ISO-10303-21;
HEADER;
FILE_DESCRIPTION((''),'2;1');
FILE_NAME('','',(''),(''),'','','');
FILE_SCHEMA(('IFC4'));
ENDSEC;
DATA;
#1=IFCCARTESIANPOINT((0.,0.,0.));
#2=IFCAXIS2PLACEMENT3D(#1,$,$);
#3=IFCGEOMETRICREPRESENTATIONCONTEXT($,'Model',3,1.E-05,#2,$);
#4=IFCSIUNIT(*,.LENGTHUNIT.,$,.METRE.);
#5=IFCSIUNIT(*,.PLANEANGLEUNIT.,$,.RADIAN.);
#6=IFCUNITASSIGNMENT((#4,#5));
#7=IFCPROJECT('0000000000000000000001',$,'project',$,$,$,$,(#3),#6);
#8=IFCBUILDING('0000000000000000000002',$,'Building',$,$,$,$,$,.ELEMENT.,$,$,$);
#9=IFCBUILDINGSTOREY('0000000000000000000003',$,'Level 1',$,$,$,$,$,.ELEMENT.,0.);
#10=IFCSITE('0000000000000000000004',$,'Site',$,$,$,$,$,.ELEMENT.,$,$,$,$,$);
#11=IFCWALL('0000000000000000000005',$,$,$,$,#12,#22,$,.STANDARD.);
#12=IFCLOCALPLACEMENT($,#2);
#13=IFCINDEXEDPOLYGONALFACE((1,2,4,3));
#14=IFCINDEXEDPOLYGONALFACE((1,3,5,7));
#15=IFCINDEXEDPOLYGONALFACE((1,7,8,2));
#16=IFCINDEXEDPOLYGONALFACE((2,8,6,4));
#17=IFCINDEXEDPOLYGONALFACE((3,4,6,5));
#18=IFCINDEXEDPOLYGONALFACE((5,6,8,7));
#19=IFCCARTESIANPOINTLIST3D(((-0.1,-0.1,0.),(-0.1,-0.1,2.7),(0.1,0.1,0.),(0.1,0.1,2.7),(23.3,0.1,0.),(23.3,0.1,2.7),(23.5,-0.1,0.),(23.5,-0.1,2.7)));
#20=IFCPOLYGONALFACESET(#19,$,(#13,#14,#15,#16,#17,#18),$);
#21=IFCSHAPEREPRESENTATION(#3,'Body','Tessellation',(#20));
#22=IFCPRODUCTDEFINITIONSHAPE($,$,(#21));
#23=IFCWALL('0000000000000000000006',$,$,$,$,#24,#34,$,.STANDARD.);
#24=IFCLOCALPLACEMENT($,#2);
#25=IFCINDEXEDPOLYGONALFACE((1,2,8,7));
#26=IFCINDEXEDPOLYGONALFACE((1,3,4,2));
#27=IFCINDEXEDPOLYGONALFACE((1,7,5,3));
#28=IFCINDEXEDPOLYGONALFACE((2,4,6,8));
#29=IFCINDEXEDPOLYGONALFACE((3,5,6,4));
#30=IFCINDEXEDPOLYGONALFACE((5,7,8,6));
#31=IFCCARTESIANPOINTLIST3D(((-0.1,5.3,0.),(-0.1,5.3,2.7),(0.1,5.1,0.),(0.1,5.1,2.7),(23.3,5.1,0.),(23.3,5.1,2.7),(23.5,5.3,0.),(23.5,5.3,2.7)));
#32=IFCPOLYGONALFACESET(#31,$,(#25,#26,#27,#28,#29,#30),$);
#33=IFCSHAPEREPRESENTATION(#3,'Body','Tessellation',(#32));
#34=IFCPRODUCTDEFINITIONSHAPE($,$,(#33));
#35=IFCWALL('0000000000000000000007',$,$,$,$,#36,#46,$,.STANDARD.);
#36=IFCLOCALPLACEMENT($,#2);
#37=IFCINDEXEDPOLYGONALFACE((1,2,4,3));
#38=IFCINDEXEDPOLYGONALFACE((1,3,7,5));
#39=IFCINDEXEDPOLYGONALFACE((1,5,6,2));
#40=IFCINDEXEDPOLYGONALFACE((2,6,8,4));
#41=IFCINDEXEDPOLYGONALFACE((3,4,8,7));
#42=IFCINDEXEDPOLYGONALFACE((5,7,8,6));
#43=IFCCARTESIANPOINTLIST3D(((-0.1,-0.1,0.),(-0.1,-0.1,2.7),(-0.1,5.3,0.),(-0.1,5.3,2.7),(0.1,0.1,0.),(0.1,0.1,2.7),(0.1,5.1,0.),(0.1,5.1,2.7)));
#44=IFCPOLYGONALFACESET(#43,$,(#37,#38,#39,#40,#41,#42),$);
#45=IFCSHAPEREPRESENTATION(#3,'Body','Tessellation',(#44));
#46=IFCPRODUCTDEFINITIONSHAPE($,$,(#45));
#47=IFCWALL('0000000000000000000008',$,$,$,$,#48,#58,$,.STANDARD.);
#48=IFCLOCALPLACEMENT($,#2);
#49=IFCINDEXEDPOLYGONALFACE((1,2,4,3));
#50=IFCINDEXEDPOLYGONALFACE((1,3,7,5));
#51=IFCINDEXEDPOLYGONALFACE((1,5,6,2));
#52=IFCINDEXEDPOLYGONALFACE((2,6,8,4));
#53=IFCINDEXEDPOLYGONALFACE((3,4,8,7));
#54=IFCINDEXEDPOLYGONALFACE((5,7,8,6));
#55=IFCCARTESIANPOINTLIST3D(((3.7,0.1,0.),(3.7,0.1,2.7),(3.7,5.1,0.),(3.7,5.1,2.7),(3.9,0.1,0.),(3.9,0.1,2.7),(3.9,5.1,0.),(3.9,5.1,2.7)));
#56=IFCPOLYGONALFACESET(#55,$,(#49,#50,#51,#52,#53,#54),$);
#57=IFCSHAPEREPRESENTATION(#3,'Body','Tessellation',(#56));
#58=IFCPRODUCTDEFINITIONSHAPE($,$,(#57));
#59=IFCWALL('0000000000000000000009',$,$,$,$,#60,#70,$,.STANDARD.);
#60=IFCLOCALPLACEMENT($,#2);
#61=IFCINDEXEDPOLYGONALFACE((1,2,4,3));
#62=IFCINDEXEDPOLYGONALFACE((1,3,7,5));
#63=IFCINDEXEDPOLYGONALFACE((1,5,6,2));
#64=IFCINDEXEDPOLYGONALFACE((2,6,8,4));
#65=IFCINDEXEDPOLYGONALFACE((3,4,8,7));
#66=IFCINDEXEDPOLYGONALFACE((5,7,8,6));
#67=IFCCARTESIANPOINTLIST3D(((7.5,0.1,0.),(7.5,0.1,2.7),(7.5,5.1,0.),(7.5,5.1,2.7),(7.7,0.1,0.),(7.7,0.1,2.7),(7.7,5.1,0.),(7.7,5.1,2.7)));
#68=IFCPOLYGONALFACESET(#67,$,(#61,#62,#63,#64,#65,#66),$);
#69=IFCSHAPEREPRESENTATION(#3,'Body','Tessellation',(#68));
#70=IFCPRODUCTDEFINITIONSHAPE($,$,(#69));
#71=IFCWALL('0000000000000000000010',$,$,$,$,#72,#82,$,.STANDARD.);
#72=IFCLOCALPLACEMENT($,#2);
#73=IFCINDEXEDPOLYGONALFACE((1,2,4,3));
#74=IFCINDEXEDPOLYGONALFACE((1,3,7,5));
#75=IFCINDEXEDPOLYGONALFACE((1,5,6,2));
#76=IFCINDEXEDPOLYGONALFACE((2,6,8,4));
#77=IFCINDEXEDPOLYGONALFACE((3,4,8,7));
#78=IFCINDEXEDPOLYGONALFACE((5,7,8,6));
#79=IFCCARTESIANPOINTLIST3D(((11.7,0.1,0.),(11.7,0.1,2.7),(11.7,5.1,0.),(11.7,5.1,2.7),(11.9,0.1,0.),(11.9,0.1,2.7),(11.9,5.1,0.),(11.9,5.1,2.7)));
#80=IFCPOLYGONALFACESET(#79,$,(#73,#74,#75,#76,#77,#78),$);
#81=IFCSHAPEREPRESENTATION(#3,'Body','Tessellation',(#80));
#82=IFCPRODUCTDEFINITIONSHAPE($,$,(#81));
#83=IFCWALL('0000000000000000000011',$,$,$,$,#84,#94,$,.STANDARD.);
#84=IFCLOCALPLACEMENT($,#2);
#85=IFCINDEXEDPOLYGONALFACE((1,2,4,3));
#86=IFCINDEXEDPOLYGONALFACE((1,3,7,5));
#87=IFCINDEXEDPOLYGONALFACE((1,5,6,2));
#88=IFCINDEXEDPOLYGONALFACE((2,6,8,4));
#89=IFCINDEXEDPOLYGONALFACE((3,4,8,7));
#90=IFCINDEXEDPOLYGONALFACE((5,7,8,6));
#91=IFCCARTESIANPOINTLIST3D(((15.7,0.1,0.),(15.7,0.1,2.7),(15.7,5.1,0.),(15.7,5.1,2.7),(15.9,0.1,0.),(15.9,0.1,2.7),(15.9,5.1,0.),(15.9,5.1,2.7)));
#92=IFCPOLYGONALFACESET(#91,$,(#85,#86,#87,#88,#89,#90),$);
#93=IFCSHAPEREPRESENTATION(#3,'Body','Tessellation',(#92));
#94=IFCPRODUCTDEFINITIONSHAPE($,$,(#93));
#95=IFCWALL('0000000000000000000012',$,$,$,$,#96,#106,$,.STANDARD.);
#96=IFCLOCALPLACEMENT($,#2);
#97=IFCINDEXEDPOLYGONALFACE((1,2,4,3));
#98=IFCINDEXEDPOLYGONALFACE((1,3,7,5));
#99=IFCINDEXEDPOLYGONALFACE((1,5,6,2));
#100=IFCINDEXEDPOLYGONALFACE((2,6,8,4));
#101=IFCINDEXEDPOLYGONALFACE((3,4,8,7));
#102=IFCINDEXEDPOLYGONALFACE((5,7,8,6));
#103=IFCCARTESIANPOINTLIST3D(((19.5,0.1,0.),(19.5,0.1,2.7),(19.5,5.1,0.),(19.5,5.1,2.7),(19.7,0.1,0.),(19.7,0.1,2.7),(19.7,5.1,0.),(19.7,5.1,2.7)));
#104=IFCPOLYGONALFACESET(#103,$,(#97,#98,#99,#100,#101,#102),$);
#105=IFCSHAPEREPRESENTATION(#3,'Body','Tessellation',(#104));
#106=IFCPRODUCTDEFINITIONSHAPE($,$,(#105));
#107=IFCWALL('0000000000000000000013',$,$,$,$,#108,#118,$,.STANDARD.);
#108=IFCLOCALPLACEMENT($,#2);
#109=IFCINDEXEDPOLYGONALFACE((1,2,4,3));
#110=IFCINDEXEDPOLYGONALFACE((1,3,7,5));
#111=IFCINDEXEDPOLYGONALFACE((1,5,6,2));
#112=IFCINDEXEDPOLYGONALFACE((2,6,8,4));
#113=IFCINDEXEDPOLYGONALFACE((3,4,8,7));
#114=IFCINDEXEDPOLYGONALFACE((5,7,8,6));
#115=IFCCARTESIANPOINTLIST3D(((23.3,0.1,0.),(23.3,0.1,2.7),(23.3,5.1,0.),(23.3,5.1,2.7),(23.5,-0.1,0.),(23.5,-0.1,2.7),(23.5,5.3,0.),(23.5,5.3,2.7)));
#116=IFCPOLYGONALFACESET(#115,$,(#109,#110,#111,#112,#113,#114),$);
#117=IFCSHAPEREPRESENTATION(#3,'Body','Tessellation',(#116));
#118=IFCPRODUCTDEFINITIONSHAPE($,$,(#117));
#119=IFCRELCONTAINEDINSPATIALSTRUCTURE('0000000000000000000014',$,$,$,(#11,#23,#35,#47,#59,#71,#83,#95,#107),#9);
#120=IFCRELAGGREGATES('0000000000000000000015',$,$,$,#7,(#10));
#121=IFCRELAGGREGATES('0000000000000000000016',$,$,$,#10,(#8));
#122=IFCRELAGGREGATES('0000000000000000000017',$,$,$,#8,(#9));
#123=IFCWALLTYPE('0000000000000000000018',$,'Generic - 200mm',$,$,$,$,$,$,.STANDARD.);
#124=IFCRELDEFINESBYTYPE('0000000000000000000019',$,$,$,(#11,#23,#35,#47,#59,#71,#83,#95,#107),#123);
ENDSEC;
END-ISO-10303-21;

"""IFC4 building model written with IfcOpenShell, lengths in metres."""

from ifc_helpers import new_model, si_unit, frame, frame_2d, origin, place, context, project, spatial, polyline, rectangle, outline, extrude, type_object, element, save


model = new_model("IFC4")

# Units and contexts
model_context = context("Model", 3, precision=1e-05, world=origin())
ifc_project = project(units=[si_unit("LENGTHUNIT", "METRE"), si_unit("PLANEANGLEUNIT", "RADIAN")], contexts=[model_context])

# Site, building, storey
site = spatial("IfcSite", under=ifc_project, Name="Site", CompositionType="ELEMENT")
building = spatial("IfcBuilding", under=site, Name="Building", CompositionType="ELEMENT")
storey = spatial("IfcBuildingStorey", under=building, Name="Level 1", CompositionType="ELEMENT", Elevation=0.0)

# Walls
wall_type = type_object("IfcWallType", Name="Generic - 200mm", PredefinedType="STANDARD")
wall_1_placement = place(None, frame((-0.1, 0.0, 0.0), z_axis=(0.0, 0.0, 1.0), x_axis=(1.0, 0.0, 0.0)))
element("IfcWall", 1, at=wall_1_placement, inside=storey, type_object=wall_type, PredefinedType="STANDARD", context=model_context, shape_type="SweptSolid", body=[
    extrude(outline(polyline([(0.0, -0.1), (23.6, -0.1), (23.4, 0.1), (0.2, 0.1), (0.0, -0.1)])), origin(), (0.0, 0.0, 1.0), 2.7),
])
wall_2_placement = place(None, frame((-0.1, 5.2, 0.0), z_axis=(0.0, 0.0, 1.0), x_axis=(1.0, 0.0, 0.0)))
element("IfcWall", 2, at=wall_2_placement, inside=storey, type_object=wall_type, PredefinedType="STANDARD", context=model_context, shape_type="SweptSolid", body=[
    extrude(outline(polyline([(0.2, -0.1), (23.4, -0.1), (23.6, 0.1), (0.0, 0.1), (0.2, -0.1)])), origin(), (0.0, 0.0, 1.0), 2.7),
])
wall_3_placement = place(None, frame((0.0, 0.1, 0.0), z_axis=(0.0, 0.0, 1.0), x_axis=(0.0, 1.0, 0.0)))
element("IfcWall", 3, at=wall_3_placement, inside=storey, type_object=wall_type, PredefinedType="STANDARD", context=model_context, shape_type="SweptSolid", body=[
    extrude(outline(polyline([(0.0, -0.1), (5.0, -0.1), (5.2, 0.1), (-0.2, 0.1), (0.0, -0.1)])), origin(), (0.0, 0.0, 1.0), 2.7),
])
for number, where, z_axis, x_axis in (
    (4, (3.8, 0.1, 0.0), (0.0, 0.0, 1.0), (0.0, 1.0, 0.0)),
    (5, (7.6, 0.1, 0.0), (0.0, 0.0, 1.0), (0.0, 1.0, 0.0)),
    (6, (11.8, 0.1, 0.0), (0.0, 0.0, 1.0), (0.0, 1.0, 0.0)),
    (7, (15.8, 0.1, 0.0), (0.0, 0.0, 1.0), (0.0, 1.0, 0.0)),
    (8, (19.6, 0.1, 0.0), (0.0, 0.0, 1.0), (0.0, 1.0, 0.0)),
):
    element("IfcWall", number, at=place(None, frame(where, z_axis=z_axis, x_axis=x_axis)), inside=storey, type_object=wall_type, PredefinedType="STANDARD", context=model_context, shape_type="SweptSolid", body=[
        extrude(rectangle(XDim=5.0, YDim=0.2, at=frame_2d((2.5, 0.0))), origin(), (0.0, 0.0, 1.0), 2.7),
    ])
wall_4_placement = place(None, frame((23.4, 0.1, 0.0), z_axis=(0.0, 0.0, 1.0), x_axis=(0.0, 1.0, 0.0)))
element("IfcWall", 9, at=wall_4_placement, inside=storey, type_object=wall_type, PredefinedType="STANDARD", context=model_context, shape_type="SweptSolid", body=[
    extrude(outline(polyline([(-0.2, -0.1), (5.2, -0.1), (5.0, 0.1), (0.0, 0.1), (-0.2, -0.1)])), origin(), (0.0, 0.0, 1.0), 2.7),
])

save(model, "model.ifc")
